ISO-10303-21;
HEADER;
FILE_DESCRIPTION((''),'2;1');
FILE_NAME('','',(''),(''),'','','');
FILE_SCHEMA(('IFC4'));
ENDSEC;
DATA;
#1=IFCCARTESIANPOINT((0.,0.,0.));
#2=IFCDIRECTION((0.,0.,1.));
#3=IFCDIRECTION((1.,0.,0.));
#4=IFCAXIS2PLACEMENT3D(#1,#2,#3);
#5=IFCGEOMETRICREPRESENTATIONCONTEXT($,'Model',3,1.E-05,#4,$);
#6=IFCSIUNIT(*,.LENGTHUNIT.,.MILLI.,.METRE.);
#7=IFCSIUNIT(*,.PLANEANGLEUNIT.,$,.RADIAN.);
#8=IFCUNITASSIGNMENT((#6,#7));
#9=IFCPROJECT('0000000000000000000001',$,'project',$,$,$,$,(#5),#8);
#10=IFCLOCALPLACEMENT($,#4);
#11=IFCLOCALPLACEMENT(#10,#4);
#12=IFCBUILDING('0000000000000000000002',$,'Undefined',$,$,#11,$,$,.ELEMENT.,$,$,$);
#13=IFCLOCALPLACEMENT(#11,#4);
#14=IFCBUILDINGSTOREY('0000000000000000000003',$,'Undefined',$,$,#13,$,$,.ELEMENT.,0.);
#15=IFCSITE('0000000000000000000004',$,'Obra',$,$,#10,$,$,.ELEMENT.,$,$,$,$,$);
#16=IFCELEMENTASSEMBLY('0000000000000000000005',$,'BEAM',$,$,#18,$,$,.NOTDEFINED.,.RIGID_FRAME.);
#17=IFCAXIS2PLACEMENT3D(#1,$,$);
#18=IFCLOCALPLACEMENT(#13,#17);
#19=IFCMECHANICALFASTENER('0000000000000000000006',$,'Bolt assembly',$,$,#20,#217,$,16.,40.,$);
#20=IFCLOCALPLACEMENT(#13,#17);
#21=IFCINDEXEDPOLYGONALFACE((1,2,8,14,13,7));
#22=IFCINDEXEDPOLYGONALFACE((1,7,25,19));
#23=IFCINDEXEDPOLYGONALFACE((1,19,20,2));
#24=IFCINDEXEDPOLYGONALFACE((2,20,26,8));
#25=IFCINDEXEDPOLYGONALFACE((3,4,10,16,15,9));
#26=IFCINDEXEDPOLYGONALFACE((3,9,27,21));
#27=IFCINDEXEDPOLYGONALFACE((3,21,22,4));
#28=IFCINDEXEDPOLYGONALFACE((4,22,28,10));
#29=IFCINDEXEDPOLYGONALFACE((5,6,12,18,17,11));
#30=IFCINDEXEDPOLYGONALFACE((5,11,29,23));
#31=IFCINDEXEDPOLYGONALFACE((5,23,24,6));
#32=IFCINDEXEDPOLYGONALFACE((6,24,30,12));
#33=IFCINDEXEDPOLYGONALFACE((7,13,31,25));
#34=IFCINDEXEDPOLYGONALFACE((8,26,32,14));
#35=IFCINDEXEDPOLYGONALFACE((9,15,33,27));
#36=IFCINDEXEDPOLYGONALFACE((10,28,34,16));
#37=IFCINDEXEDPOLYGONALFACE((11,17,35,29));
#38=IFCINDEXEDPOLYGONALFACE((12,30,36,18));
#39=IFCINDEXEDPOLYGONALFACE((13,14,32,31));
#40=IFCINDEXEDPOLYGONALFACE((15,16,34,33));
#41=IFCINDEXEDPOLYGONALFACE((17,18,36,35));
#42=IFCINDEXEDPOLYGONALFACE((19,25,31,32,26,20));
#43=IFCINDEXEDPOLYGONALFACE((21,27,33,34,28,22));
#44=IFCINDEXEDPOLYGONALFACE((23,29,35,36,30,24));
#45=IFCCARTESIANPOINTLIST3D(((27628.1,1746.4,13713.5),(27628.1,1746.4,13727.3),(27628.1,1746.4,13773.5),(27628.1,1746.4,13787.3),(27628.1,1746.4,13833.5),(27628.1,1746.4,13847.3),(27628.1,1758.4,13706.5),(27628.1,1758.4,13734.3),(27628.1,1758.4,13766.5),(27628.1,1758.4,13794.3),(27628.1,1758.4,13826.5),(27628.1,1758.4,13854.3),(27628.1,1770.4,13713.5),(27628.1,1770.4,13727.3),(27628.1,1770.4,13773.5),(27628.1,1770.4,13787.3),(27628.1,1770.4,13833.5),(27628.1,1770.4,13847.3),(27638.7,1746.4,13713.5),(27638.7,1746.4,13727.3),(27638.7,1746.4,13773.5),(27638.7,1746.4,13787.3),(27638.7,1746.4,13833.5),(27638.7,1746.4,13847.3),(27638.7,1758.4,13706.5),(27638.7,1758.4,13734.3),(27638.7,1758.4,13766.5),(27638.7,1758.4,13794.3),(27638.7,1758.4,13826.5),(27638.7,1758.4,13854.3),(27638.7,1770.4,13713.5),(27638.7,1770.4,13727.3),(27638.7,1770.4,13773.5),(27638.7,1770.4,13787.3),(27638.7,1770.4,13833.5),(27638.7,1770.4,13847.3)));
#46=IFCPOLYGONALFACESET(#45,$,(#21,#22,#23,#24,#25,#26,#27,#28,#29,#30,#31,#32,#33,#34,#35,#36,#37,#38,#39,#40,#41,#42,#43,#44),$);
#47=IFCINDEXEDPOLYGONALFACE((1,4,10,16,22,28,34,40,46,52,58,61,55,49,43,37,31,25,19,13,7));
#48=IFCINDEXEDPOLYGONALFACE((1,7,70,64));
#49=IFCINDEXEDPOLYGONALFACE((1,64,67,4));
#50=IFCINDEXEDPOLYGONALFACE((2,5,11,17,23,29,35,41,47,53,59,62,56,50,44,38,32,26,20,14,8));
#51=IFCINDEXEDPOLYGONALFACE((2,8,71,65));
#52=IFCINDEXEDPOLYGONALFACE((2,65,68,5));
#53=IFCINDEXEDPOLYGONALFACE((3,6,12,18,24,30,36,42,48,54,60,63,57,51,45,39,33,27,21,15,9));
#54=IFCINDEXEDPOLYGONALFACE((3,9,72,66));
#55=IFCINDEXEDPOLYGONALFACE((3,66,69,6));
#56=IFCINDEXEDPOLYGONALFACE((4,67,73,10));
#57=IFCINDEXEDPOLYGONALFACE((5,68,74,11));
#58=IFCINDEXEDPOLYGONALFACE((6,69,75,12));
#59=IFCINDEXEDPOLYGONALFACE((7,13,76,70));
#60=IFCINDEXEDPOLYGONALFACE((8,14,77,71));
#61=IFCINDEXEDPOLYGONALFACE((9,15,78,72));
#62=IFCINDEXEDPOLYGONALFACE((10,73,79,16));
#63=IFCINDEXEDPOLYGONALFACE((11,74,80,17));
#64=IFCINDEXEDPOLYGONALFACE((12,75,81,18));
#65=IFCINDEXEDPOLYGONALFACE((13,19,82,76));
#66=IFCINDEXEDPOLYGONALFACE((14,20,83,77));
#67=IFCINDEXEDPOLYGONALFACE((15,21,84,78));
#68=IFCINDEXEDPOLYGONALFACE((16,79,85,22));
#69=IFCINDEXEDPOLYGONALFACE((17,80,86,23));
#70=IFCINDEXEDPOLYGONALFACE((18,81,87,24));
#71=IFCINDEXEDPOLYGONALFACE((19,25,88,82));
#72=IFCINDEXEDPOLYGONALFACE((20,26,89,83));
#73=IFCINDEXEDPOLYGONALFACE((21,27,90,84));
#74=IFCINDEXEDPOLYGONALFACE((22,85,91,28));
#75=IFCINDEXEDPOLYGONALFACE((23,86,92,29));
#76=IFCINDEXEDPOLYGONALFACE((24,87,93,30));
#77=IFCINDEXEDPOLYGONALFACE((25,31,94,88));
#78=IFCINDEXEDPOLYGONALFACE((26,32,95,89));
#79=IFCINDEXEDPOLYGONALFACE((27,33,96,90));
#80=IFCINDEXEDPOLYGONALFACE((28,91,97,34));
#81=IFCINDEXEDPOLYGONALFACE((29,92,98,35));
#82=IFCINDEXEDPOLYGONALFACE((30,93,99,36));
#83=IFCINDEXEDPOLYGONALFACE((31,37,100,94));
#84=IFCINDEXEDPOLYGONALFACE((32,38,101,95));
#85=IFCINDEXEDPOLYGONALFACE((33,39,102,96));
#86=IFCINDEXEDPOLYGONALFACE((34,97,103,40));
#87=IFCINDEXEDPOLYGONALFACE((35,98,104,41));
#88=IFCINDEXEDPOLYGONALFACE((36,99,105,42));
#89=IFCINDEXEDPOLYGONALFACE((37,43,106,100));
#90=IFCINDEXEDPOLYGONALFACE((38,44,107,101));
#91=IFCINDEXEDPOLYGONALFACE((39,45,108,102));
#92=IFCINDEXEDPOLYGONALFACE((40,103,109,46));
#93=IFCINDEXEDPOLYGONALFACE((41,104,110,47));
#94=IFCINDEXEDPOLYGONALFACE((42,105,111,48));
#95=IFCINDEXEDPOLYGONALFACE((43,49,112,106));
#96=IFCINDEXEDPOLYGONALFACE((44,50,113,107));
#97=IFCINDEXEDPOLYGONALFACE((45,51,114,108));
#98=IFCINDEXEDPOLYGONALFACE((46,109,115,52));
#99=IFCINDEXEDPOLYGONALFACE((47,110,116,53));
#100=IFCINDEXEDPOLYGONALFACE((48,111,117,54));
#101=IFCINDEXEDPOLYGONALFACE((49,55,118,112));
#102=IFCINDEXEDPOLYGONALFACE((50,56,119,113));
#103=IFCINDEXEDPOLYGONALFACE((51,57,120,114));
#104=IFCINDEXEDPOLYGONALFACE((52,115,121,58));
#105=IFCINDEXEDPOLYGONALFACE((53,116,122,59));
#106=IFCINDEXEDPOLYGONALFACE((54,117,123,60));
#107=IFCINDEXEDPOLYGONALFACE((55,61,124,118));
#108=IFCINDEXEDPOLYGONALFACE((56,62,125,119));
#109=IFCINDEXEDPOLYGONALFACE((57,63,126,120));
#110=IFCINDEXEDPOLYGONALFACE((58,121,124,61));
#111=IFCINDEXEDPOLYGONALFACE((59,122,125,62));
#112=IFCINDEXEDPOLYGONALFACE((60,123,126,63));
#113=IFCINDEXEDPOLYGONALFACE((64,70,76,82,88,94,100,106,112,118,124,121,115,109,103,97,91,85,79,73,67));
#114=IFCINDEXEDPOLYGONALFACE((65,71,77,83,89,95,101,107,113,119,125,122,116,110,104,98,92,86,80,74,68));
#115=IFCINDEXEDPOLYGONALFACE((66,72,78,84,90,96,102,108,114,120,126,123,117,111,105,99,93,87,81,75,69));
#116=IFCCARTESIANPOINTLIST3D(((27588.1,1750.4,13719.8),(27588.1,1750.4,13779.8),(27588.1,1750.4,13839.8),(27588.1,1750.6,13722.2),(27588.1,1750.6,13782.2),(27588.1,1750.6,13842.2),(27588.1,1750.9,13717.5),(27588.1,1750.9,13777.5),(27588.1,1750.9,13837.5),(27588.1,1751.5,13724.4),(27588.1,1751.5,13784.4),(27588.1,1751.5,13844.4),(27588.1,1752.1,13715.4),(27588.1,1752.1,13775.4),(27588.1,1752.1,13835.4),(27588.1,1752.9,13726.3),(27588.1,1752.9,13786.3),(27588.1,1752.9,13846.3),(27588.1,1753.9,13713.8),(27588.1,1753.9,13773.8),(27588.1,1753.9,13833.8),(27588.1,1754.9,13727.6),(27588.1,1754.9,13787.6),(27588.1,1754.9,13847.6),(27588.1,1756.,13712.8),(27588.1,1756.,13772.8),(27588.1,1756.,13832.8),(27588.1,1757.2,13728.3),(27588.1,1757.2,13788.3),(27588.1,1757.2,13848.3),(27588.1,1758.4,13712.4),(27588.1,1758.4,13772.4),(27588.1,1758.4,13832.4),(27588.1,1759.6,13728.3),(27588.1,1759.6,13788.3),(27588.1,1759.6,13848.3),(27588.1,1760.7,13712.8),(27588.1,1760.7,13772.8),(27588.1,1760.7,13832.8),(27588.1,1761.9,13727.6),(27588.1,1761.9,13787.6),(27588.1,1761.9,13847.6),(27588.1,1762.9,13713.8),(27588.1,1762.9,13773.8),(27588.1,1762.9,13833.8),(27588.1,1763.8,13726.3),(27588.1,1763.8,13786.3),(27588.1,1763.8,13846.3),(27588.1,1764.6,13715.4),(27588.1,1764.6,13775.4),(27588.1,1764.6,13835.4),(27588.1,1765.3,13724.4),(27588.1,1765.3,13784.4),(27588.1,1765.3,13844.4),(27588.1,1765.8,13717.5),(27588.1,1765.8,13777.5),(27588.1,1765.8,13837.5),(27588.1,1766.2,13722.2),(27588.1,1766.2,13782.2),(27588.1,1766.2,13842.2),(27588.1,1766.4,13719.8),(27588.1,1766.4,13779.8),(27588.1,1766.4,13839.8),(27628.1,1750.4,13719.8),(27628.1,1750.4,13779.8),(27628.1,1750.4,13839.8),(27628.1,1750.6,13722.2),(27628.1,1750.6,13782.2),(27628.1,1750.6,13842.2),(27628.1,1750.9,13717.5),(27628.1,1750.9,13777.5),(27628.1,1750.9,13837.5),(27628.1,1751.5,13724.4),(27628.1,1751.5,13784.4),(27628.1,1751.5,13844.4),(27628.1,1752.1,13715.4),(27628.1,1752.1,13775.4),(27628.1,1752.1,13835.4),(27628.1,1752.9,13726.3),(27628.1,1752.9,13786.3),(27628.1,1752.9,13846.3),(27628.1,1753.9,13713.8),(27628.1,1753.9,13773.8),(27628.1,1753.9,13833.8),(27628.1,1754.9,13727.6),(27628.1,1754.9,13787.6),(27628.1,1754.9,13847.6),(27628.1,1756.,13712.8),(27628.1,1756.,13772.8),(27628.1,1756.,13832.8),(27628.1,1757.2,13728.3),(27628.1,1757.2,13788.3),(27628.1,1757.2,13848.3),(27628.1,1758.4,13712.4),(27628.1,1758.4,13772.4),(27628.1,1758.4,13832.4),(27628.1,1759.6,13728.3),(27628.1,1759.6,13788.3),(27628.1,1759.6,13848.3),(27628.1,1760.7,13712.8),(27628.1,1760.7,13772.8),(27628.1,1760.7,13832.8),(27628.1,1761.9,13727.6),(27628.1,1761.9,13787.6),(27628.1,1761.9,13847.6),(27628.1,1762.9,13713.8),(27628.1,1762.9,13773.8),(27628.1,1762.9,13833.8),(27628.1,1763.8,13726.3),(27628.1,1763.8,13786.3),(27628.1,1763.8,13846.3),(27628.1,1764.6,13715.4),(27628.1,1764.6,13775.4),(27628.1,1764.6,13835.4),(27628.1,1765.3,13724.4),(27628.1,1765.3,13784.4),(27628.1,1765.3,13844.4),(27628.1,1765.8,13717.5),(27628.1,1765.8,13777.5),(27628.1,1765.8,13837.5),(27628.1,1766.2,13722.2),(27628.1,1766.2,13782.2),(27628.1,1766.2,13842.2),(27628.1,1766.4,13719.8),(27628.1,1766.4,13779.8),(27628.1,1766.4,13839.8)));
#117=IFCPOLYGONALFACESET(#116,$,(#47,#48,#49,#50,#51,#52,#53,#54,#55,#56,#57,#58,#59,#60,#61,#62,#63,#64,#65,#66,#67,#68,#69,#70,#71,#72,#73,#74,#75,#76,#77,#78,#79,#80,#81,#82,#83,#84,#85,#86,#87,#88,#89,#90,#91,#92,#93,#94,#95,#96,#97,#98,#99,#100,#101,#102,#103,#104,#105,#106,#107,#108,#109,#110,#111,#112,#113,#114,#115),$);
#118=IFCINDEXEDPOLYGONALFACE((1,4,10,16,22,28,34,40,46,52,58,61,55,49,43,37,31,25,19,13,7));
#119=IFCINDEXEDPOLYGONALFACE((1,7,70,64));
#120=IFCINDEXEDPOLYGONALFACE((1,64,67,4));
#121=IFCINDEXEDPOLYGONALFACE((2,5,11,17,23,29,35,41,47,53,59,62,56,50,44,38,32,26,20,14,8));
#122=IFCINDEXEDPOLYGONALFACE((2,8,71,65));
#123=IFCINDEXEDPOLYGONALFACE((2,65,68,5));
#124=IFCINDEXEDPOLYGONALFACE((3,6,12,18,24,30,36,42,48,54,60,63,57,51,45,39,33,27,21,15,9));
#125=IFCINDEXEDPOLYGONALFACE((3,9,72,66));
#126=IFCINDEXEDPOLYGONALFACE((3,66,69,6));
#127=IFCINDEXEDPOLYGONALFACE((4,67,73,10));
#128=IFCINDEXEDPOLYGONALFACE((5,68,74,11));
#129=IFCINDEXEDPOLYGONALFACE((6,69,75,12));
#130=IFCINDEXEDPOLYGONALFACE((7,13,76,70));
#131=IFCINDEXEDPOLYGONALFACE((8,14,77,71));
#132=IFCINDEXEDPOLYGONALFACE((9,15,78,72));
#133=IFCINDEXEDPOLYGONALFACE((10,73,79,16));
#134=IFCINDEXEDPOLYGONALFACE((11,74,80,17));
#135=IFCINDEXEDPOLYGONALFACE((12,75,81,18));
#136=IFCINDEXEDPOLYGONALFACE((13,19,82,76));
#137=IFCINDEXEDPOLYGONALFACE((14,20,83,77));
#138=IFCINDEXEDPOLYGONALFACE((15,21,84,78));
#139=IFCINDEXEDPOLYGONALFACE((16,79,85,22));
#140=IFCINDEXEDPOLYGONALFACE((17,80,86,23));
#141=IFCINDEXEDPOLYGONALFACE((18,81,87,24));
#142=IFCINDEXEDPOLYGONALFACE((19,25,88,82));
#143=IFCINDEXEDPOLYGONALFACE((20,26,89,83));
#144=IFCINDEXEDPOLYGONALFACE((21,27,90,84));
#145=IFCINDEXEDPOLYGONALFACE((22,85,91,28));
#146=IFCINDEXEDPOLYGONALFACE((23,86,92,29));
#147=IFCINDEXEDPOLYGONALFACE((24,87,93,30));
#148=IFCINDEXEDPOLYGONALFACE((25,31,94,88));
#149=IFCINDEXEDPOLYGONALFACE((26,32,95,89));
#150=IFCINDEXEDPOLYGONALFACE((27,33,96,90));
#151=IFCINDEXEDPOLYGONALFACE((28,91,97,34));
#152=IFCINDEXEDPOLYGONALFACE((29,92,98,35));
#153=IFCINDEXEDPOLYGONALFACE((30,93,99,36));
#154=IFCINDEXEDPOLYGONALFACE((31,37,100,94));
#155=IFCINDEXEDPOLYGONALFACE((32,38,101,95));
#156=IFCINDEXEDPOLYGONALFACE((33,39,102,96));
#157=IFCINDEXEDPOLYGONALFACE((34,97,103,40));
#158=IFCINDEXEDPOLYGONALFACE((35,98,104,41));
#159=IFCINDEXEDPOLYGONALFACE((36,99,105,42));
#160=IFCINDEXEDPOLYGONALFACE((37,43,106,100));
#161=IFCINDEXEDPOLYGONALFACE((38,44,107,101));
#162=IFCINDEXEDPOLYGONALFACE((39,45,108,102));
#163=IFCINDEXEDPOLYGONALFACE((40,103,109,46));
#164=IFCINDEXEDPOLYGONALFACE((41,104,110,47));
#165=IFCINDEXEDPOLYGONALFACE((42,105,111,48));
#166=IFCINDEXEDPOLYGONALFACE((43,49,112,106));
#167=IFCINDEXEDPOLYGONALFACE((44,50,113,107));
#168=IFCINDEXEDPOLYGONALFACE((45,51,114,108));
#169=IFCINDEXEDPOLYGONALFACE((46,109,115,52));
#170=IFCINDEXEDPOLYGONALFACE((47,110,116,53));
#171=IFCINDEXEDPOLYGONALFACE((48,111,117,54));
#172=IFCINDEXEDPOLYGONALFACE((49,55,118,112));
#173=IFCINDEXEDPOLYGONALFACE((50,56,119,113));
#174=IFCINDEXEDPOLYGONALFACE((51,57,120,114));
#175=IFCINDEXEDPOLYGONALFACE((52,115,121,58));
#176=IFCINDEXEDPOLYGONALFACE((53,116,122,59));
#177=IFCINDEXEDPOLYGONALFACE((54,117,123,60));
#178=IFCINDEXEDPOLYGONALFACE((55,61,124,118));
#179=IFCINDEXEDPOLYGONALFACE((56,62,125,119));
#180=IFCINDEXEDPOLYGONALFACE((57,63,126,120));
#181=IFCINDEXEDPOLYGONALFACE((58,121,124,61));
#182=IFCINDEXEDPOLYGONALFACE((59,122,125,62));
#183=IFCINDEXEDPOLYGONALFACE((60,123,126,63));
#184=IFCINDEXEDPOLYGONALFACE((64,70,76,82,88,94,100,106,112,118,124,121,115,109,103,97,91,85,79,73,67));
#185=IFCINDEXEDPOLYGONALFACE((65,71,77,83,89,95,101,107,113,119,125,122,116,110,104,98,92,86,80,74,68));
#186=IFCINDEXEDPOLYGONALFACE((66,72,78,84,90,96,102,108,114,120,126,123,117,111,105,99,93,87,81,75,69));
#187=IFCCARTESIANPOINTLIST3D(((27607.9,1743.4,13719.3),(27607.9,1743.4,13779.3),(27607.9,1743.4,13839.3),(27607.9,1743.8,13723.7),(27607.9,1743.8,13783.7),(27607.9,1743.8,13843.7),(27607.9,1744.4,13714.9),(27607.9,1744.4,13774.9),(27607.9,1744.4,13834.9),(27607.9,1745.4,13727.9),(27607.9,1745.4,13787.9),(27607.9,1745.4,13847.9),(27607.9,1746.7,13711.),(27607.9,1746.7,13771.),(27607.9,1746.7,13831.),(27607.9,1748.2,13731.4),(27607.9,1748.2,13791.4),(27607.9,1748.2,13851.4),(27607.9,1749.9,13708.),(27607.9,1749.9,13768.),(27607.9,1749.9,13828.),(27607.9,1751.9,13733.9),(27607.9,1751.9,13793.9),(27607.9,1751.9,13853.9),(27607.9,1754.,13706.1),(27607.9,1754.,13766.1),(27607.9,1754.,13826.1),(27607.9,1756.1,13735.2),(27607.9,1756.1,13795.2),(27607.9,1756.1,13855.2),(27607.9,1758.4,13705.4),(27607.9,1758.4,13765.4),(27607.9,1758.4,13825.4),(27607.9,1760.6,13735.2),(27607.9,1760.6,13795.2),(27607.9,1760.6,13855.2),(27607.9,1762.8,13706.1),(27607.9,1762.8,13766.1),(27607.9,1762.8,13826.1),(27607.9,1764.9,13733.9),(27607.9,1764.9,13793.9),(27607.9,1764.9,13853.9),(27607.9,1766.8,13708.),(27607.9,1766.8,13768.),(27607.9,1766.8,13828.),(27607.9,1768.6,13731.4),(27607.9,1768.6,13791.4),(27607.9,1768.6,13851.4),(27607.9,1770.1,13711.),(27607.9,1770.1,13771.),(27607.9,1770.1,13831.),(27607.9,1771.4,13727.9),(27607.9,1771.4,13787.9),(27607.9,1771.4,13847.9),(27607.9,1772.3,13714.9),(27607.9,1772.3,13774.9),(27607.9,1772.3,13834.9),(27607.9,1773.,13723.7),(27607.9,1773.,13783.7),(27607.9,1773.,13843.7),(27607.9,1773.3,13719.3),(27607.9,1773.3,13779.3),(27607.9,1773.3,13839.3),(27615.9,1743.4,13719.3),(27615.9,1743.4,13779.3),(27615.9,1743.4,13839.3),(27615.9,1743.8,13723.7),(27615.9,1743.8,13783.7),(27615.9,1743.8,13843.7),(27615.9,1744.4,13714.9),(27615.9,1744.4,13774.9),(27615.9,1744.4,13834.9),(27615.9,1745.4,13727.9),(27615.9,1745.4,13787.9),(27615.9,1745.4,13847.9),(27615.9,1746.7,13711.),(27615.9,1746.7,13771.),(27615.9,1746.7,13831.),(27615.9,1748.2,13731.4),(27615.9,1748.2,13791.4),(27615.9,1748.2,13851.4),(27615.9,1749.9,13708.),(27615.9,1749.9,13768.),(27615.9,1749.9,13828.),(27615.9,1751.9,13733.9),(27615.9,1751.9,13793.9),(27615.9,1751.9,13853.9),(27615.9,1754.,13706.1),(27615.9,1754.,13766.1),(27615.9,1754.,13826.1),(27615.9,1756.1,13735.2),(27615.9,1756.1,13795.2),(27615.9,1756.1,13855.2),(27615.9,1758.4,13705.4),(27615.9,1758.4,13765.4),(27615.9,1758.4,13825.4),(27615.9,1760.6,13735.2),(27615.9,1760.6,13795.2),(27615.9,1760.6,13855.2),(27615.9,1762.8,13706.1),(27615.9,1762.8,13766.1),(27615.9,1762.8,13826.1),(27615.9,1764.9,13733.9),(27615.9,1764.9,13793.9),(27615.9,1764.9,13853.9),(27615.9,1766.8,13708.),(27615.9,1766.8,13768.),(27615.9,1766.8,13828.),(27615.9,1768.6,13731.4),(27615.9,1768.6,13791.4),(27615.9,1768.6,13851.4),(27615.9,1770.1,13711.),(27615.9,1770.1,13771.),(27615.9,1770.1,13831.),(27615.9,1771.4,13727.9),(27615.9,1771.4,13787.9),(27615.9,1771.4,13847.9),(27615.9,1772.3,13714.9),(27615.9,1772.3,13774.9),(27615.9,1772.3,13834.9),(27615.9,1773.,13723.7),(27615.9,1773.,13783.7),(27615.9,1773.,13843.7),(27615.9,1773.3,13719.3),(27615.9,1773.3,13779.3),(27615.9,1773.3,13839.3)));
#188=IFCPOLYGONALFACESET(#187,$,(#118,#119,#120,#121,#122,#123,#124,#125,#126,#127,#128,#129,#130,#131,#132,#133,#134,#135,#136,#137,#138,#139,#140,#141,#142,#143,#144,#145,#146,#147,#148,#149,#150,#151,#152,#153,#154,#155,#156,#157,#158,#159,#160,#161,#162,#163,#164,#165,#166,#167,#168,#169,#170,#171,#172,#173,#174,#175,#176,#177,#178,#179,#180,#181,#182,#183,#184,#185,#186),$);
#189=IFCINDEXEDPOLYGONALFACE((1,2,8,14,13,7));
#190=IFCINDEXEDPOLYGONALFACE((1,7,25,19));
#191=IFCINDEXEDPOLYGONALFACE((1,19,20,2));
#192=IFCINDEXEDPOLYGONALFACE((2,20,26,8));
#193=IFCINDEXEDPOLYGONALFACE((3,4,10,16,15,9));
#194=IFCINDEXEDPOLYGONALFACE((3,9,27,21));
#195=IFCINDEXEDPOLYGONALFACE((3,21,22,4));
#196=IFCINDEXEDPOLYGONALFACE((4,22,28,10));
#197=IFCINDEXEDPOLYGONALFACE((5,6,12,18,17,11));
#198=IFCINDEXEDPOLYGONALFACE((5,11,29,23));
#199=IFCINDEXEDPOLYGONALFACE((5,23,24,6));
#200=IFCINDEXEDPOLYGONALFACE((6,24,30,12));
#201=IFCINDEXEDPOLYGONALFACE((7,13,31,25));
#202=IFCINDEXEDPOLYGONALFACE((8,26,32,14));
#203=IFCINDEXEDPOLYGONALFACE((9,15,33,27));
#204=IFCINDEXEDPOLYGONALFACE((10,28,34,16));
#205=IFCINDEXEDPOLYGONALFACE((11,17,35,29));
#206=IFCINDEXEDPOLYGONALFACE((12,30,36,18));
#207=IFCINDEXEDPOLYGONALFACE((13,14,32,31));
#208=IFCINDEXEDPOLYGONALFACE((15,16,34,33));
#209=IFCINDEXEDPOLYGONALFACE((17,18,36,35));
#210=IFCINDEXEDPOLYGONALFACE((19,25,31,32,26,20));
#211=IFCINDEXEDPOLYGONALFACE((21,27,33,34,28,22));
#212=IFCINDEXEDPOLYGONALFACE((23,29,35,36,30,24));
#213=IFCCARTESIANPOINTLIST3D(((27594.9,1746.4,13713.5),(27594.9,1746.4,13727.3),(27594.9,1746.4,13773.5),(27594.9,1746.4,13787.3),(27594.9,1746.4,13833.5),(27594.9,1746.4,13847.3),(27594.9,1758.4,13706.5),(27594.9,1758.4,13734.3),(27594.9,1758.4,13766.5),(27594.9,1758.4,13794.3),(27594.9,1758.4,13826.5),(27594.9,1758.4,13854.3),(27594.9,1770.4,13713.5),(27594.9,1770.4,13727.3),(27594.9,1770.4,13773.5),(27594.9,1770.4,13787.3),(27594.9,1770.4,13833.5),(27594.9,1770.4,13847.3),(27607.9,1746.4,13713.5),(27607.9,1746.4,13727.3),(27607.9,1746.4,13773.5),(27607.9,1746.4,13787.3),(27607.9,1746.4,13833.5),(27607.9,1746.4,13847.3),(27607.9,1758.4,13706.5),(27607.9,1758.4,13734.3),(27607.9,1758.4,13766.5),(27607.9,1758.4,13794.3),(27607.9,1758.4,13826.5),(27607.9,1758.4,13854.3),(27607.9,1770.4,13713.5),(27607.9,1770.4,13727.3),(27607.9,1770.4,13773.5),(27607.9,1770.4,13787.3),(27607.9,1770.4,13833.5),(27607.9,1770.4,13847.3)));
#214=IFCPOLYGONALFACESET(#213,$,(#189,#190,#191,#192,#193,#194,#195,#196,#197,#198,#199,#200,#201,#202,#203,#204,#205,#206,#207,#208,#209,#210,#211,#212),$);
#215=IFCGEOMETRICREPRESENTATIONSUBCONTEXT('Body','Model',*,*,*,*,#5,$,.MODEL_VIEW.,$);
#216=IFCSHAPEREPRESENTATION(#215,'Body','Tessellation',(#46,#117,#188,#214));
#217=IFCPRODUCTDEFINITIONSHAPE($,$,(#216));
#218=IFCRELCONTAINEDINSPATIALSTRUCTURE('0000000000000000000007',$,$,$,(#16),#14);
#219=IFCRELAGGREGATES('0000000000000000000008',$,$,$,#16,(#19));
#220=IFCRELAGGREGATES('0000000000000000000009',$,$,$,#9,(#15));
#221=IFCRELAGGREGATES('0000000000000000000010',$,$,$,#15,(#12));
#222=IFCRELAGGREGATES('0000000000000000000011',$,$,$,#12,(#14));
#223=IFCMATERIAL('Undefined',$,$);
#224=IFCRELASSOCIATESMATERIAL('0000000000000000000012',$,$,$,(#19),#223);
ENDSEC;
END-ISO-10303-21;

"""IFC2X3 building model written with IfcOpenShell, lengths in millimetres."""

from ifc_helpers import new_model, si_unit, frame, origin_with_axes, origin_2d_with_axis, place, context, subcontext, project, spatial, polyline, circle, outline, extrude, source, transform, mapped, material, element, aggregate, save


model = new_model("IFC2X3")

# Units and contexts
model_context = context("Model", 3, precision=1e-05, world=origin_with_axes())
body_context = subcontext(model_context, "Body", "Model", "MODEL_VIEW")
ifc_project = project(units=[si_unit("LENGTHUNIT", "METRE", prefix="MILLI"), si_unit("PLANEANGLEUNIT", "RADIAN")], contexts=[model_context])

# Site, building, storey
site_placement = place(None, origin_with_axes())
site = spatial("IfcSite", under=ifc_project, at=site_placement, Name="Obra", CompositionType="ELEMENT")
building_placement = place(site_placement, origin_with_axes())
building = spatial("IfcBuilding", under=site, at=building_placement, Name="Undefined", CompositionType="ELEMENT")
storey_placement = place(building_placement, origin_with_axes())
storey = spatial("IfcBuildingStorey", under=building, at=storey_placement, Name="Undefined", CompositionType="ELEMENT", Elevation=0.0)

# Shared definitions
ifc_material_1 = material(Name="Undefined")

# Element assembly, mechanical fastener
shared_shape_1 = source(origin_with_axes(), body_context, "Body", "SweptSolid", [
    extrude(outline(polyline([(13.9, 0.0), (6.9, 12.0), (-6.9, 12.0), (-13.9, 0.0), (-6.9, -12.0), (6.9, -12.0), (13.9, 0.0)])), frame((0.0, -13.7, 0.0), z_axis=(0.0, 1.0, 0.0), x_axis=(1.0, 0.0, 0.0)), (0.0, 0.0, 1.0), 10.6),
    extrude(circle(Radius=8.0, at=origin_2d_with_axis()), frame((0.0, -3.1, 0.0), z_axis=(0.0, 1.0, 0.0), x_axis=(1.0, 0.0, 0.0)), (0.0, 0.0, 1.0), 40.0),
    extrude(circle(Radius=15.0, at=origin_2d_with_axis()), frame((0.0, 9.1, 0.0), z_axis=(0.0, 1.0, 0.0), x_axis=(1.0, 0.0, 0.0)), (0.0, 0.0, 1.0), 8.0),
    extrude(outline(polyline([(13.9, 0.0), (6.9, 12.0), (-6.9, 12.0), (-13.9, 0.0), (-6.9, -12.0), (6.9, -12.0), (13.9, 0.0)])), frame((0.0, 17.1, 0.0), z_axis=(0.0, 1.0, 0.0), x_axis=(1.0, 0.0, 0.0)), (0.0, 0.0, 1.0), 13.0),
])
assembly_1_placement = place(storey_placement, origin_with_axes())
assembly_1 = element("IfcElementAssembly", 1, at=assembly_1_placement, inside=storey, Name="BEAM", AssemblyPlace="NOTDEFINED", PredefinedType="RIGID_FRAME")
mechanical_fastener_1_placement = place(assembly_1_placement, frame((27625.0, 1708.4, 13875.4), z_axis=(0.0, 1.0, 0.0), x_axis=(0.0, 0.0, -1.0)))
mechanical_fastener_1 = element("IfcMechanicalFastener", 2, at=mechanical_fastener_1_placement, material=ifc_material_1, Name="Bolt assembly", NominalDiameter=16.0, NominalLength=40.0, context=body_context, shape_type="MappedRepresentation", body=[
    mapped(shared_shape_1, transform((35.0, 0.0, 50.0))),
    mapped(shared_shape_1, transform((95.0, 0.0, 50.0))),
    mapped(shared_shape_1, transform((155.0, 0.0, 50.0))),
])
aggregate(assembly_1, [mechanical_fastener_1])

save(model, "model.ifc")
